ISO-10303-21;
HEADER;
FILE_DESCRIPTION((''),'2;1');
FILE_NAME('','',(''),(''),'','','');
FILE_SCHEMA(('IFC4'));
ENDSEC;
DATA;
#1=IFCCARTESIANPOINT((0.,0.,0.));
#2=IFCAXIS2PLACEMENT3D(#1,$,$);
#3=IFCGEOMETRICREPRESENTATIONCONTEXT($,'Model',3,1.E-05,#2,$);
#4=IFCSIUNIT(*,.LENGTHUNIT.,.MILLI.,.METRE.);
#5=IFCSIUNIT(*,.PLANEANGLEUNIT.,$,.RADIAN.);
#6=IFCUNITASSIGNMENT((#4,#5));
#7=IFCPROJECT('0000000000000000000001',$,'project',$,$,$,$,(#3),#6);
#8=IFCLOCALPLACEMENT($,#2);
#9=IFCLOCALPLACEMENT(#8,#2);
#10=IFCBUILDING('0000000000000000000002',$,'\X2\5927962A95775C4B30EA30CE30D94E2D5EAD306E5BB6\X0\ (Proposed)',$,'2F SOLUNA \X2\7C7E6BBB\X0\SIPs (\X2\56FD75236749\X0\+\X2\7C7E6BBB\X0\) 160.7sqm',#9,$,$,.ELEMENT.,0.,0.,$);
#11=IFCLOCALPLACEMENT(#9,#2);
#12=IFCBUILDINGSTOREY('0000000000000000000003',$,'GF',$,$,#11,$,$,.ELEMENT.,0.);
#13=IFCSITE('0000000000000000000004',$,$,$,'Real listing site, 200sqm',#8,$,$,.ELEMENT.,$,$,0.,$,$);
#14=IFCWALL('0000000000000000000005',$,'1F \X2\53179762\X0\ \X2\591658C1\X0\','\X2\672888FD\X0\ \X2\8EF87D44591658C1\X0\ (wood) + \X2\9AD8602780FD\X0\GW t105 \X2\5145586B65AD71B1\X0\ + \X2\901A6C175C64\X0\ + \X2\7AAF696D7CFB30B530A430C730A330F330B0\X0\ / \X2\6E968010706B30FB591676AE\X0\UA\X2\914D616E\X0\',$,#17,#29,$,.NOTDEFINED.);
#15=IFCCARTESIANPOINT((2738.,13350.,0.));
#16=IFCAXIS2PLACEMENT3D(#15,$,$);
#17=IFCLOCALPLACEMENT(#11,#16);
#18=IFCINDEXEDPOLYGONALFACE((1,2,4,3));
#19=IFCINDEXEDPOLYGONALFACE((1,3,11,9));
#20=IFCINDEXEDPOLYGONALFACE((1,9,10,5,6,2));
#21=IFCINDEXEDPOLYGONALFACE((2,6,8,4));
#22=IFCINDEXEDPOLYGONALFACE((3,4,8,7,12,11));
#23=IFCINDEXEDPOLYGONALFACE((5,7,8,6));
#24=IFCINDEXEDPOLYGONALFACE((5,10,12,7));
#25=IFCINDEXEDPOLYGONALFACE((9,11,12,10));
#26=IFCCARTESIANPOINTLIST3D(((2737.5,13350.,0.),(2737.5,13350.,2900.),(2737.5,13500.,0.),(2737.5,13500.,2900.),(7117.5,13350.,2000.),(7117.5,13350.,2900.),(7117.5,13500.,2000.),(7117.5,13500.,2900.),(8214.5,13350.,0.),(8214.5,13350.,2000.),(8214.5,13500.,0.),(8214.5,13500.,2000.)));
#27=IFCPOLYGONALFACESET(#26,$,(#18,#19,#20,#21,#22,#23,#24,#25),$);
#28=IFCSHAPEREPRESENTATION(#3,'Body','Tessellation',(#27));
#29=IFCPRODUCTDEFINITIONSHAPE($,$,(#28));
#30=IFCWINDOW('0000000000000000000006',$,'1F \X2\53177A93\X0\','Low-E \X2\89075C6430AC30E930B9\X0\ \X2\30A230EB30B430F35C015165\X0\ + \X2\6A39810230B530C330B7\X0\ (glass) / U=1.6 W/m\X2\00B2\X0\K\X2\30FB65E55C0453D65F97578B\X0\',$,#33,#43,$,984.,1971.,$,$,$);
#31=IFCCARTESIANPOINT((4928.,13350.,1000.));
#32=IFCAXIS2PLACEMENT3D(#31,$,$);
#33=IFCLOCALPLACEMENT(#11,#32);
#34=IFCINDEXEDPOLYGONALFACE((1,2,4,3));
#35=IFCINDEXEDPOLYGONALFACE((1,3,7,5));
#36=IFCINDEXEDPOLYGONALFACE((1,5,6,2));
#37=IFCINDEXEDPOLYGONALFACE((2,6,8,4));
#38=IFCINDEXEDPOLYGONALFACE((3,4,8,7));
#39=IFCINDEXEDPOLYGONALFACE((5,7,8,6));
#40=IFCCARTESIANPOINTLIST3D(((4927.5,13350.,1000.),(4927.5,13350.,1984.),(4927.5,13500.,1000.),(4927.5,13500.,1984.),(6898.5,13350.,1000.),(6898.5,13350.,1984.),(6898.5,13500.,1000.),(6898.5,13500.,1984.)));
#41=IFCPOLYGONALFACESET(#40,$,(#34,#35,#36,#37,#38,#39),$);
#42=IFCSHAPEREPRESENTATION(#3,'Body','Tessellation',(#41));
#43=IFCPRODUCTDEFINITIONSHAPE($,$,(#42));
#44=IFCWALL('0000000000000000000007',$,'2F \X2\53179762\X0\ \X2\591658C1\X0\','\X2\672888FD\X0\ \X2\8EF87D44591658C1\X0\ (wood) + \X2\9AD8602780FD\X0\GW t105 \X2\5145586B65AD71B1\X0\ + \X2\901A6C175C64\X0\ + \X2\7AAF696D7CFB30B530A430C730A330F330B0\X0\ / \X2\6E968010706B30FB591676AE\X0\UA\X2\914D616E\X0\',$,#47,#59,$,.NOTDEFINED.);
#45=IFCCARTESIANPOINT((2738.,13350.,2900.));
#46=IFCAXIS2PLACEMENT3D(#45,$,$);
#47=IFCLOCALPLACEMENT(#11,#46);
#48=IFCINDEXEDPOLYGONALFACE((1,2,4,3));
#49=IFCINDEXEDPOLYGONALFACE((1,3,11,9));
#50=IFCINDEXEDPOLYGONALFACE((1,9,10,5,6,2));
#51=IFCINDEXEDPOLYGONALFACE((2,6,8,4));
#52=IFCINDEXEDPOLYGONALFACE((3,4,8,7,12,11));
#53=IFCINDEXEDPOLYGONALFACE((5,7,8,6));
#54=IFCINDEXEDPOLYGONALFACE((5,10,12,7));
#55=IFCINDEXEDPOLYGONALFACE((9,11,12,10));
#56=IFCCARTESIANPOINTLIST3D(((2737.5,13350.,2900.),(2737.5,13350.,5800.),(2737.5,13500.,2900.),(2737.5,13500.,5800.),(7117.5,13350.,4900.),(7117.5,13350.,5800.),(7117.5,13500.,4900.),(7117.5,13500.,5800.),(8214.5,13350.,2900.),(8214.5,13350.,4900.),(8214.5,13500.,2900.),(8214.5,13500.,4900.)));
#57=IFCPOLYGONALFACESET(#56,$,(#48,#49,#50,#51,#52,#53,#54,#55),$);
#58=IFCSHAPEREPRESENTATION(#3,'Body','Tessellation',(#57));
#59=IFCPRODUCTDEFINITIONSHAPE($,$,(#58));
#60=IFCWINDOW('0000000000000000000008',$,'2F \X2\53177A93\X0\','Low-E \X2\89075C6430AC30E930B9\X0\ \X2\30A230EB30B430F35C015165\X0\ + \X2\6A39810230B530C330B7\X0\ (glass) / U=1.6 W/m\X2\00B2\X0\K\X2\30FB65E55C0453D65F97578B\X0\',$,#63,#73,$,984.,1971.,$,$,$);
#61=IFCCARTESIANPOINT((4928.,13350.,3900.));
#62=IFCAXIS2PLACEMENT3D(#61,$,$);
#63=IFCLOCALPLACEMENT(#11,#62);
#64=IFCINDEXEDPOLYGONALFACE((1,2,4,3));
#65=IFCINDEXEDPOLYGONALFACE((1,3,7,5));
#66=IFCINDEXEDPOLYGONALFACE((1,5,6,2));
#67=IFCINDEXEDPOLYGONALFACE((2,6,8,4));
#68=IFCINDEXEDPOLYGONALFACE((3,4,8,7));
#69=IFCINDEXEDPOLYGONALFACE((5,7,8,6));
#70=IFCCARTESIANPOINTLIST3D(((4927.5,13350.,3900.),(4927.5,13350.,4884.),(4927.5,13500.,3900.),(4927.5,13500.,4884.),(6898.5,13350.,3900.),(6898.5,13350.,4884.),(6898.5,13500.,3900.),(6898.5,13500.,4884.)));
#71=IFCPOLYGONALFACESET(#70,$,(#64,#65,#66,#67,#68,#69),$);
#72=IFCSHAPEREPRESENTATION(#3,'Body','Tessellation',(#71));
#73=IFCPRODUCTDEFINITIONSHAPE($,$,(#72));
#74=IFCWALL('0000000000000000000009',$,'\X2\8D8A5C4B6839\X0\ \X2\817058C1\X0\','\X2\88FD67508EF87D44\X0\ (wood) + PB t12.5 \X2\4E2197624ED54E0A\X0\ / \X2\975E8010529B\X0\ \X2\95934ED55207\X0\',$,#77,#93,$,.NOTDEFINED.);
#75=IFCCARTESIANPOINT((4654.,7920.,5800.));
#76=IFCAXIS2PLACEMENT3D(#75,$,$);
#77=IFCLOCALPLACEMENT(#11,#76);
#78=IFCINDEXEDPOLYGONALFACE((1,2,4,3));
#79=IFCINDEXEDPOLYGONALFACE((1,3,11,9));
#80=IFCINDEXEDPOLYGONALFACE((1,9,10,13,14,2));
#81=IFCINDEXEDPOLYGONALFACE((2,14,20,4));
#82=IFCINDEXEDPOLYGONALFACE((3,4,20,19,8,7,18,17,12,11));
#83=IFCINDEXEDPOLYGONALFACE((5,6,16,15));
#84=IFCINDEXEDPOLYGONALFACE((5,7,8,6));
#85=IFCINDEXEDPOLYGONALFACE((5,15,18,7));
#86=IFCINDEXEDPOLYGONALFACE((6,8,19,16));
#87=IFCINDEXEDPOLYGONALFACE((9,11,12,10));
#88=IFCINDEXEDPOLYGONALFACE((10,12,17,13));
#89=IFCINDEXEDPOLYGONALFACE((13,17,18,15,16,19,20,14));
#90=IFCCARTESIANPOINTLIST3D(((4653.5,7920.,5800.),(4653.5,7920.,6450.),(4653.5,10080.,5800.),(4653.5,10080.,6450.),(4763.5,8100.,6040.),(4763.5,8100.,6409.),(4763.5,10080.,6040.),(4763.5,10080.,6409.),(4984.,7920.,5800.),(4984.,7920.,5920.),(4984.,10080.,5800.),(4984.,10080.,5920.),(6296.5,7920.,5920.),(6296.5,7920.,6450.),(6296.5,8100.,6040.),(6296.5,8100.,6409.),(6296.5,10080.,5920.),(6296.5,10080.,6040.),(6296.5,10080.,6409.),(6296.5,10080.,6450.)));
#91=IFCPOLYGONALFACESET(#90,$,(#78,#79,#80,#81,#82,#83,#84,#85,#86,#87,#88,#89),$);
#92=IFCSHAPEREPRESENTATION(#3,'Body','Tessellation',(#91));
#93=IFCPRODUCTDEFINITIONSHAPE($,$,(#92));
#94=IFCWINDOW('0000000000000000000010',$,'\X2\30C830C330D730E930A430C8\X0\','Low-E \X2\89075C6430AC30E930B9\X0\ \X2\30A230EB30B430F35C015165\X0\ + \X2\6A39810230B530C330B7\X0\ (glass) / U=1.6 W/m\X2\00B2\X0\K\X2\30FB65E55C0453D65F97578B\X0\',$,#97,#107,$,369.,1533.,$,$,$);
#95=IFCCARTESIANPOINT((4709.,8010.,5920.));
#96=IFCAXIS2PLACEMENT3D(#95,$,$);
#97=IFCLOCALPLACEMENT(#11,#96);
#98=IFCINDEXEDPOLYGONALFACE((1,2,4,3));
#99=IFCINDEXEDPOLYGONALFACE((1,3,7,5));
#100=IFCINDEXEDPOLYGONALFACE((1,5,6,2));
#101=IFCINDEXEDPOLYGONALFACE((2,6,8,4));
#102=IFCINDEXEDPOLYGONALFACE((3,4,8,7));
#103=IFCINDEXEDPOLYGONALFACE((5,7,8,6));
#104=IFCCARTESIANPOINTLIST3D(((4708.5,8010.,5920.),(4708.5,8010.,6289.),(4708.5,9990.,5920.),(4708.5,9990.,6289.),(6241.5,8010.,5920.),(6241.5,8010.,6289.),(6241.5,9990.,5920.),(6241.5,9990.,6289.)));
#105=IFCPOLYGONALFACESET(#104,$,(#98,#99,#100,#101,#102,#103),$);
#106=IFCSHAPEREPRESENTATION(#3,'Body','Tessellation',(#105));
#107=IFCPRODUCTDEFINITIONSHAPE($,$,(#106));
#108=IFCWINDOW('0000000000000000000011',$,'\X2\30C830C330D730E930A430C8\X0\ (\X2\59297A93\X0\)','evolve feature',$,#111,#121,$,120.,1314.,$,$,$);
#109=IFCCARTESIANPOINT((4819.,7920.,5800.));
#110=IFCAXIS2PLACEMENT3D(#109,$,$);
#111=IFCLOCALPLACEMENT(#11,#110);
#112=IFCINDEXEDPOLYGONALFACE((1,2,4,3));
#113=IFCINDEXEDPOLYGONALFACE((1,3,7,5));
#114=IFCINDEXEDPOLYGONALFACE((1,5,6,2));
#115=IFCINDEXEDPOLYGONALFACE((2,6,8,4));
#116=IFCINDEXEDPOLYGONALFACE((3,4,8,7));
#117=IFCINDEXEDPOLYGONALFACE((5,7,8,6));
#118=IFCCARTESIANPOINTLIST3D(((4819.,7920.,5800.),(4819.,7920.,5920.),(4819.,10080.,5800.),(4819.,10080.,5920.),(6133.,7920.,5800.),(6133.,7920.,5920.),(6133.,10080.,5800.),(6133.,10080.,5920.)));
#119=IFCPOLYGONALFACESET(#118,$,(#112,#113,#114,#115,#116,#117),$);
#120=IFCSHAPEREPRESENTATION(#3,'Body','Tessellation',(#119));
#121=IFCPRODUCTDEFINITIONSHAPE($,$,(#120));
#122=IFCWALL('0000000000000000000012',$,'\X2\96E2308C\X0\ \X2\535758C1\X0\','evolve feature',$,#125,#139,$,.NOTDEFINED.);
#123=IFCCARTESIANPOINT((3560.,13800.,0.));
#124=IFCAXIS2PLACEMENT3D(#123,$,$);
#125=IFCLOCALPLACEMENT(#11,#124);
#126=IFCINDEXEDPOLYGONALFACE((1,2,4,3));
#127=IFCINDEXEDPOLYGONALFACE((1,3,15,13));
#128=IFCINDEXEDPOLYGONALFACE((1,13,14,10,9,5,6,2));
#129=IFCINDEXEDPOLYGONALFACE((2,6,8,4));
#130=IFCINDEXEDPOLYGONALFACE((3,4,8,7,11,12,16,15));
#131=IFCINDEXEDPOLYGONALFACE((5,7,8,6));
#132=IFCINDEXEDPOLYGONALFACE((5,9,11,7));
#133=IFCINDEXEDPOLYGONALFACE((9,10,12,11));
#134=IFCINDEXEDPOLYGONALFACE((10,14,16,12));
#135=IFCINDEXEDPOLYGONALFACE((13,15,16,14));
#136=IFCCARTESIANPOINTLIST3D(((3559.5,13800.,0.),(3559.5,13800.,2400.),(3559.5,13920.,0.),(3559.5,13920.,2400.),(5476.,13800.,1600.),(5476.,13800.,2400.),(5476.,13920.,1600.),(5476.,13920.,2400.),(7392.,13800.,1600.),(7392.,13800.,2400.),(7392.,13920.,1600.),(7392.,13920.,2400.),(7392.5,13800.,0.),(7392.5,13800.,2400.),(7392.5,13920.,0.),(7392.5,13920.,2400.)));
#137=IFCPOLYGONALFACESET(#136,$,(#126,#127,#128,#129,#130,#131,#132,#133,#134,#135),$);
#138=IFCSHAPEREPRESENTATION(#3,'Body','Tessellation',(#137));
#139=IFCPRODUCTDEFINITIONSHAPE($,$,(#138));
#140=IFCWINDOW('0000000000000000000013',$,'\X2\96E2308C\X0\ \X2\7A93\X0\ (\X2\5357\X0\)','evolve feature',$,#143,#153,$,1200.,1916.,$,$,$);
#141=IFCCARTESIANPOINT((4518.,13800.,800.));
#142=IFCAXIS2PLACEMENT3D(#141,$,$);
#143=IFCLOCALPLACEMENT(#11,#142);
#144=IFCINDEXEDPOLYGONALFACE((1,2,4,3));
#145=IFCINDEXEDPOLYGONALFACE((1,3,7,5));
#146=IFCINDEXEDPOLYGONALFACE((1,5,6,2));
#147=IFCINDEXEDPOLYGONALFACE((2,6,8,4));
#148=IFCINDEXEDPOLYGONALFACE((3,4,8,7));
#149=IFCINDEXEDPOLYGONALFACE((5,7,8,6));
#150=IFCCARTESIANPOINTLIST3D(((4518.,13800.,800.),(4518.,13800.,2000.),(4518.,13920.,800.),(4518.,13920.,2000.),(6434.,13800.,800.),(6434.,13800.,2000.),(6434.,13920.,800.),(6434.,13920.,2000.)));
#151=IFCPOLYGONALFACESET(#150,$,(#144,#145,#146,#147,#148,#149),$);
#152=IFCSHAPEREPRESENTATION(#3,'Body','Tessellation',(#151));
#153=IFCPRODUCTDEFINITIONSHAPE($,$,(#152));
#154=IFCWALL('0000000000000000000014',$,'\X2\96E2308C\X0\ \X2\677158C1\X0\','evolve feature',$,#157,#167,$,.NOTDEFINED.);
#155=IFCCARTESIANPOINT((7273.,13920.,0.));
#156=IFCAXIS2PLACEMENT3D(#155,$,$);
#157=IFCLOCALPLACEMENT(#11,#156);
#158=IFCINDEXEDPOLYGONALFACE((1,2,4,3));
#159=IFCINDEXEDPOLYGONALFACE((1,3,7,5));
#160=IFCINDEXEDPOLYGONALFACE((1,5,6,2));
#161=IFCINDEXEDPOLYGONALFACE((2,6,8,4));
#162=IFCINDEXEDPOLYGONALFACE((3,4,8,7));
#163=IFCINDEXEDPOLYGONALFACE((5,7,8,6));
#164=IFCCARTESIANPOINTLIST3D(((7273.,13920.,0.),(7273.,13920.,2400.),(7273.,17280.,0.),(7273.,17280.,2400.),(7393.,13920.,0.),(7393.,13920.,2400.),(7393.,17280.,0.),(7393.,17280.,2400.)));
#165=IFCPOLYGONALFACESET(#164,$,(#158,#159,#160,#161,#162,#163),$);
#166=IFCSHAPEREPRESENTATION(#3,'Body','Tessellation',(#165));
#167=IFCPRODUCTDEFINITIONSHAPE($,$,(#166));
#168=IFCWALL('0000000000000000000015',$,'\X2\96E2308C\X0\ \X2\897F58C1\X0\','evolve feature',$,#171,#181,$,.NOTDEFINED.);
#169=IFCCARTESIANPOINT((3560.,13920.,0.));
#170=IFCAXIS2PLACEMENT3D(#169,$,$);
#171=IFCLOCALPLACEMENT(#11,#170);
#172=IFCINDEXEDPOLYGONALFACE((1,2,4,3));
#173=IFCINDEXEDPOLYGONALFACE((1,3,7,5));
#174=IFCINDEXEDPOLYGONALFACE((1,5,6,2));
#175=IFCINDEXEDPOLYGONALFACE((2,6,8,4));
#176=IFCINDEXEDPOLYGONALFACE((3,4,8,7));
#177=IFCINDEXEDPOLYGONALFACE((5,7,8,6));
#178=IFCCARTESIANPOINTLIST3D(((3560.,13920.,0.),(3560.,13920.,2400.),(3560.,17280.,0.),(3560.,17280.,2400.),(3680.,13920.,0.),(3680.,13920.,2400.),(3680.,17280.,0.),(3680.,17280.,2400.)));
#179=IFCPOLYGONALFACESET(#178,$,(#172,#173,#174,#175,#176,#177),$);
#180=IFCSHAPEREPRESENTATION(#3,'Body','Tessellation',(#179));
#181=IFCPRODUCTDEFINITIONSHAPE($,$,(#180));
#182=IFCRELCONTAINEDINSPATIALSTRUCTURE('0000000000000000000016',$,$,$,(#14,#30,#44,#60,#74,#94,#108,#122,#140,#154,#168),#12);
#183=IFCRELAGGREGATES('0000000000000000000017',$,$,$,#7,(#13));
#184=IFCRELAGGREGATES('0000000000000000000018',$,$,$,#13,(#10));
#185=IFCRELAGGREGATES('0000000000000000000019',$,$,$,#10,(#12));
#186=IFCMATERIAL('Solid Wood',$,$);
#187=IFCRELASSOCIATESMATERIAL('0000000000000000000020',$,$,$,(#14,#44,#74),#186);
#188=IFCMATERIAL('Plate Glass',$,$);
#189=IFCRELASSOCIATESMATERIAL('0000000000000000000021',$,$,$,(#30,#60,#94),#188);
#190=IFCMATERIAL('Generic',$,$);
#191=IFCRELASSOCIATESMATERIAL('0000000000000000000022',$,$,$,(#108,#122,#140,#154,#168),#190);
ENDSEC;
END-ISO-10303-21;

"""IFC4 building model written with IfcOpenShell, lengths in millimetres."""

from ifc_helpers import new_model, si_unit, frame, frame_2d, origin, place, context, project, spatial, rectangle, extrude, material, element, fill, save


model = new_model("IFC4")

# Units and contexts
model_context = context("Model", 3, precision=1e-05, world=origin())
ifc_project = project(units=[si_unit("LENGTHUNIT", "METRE", prefix="MILLI"), si_unit("PLANEANGLEUNIT", "RADIAN")], contexts=[model_context])

# Site, building, storey
site_placement = place(None, origin())
site = spatial("IfcSite", under=ifc_project, at=site_placement, ObjectType="Real listing site, 200sqm", CompositionType="ELEMENT", RefElevation=0.0)
building_placement = place(site_placement, origin())
building = spatial("IfcBuilding", under=site, at=building_placement, Name="大阪長屋リノベ中庭の家 (Proposed)", ObjectType="2F SOLUNA 籾殻SIPs (国産杉+籾殻) 160.7sqm", CompositionType="ELEMENT", ElevationOfRefHeight=0.0, ElevationOfTerrain=0.0)
storey_placement = place(building_placement, origin())
storey = spatial("IfcBuildingStorey", under=building, at=storey_placement, Name="GF", CompositionType="ELEMENT", Elevation=0.0)

# Shared definitions
ifc_material_1 = material(Name="Generic")

# Wall, opening, window
ifc_material_2 = material(Name="Solid Wood")
wall_1_placement = place(storey_placement, frame((2738.0, 13350.0, 0.0)))
wall_1 = element("IfcWall", 1, at=wall_1_placement, inside=storey, material=ifc_material_2, Name="1F 北面 外壁", Description="木製 軸組外壁 (wood) + 高性能GW t105 充填断熱 + 通気層 + 窯業系サイディング / 準耐火・外皮UA配慮", PredefinedType="NOTDEFINED", context=model_context, shape_type="SweptSolid", body=[
    extrude(rectangle(XDim=5477.0, YDim=150.0, at=frame_2d((2738.0, 75.0))), frame((2738.0, 13350.0, 0.0)), (0.0, 0.0, 1.0), 2900.0),
])
opening_1_placement = place(storey_placement, frame((4928.0, 13350.0, 1000.0)))
opening_1 = element("IfcOpeningElement", 2, at=opening_1_placement, cuts=wall_1, PredefinedType="NOTDEFINED", context=model_context, shape_type="SweptSolid", body=[
    extrude(rectangle(XDim=1971.0, YDim=150.0, at=frame_2d((985.0, 75.0))), frame((4928.0, 13350.0, 1000.0)), (0.0, 0.0, 1.0), 984.0),
])
ifc_material_3 = material(Name="Plate Glass")
window_1_placement = place(storey_placement, frame((4928.0, 13350.0, 1000.0)))
window_1 = element("IfcWindow", 3, at=window_1_placement, inside=storey, material=ifc_material_3, Name="1F 北窓", Description="Low-E 複層ガラス アルゴン封入 + 樹脂サッシ (glass) / U=1.6 W/m²K・日射取得型", OverallHeight=984.0, OverallWidth=1971.0, context=model_context, shape_type="SweptSolid", body=[
    extrude(rectangle(XDim=1971.0, YDim=150.0, at=frame_2d((985.0, 75.0))), frame((4928.0, 13350.0, 1000.0)), (0.0, 0.0, 1.0), 984.0),
])
fill(opening_1, window_1)

# Wall, opening, window
wall_2_placement = place(storey_placement, frame((2738.0, 13350.0, 2900.0)))
wall_2 = element("IfcWall", 4, at=wall_2_placement, inside=storey, material=ifc_material_2, Name="2F 北面 外壁", Description="木製 軸組外壁 (wood) + 高性能GW t105 充填断熱 + 通気層 + 窯業系サイディング / 準耐火・外皮UA配慮", PredefinedType="NOTDEFINED", context=model_context, shape_type="SweptSolid", body=[
    extrude(rectangle(XDim=5477.0, YDim=150.0, at=frame_2d((2738.0, 75.0))), frame((2738.0, 13350.0, 2900.0)), (0.0, 0.0, 1.0), 2900.0),
])
opening_2_placement = place(storey_placement, frame((4928.0, 13350.0, 3900.0)))
opening_2 = element("IfcOpeningElement", 5, at=opening_2_placement, cuts=wall_2, PredefinedType="NOTDEFINED", context=model_context, shape_type="SweptSolid", body=[
    extrude(rectangle(XDim=1971.0, YDim=150.0, at=frame_2d((985.0, 75.0))), frame((4928.0, 13350.0, 3900.0)), (0.0, 0.0, 1.0), 984.0),
])
window_2_placement = place(storey_placement, frame((4928.0, 13350.0, 3900.0)))
window_2 = element("IfcWindow", 6, at=window_2_placement, inside=storey, material=ifc_material_3, Name="2F 北窓", Description="Low-E 複層ガラス アルゴン封入 + 樹脂サッシ (glass) / U=1.6 W/m²K・日射取得型", OverallHeight=984.0, OverallWidth=1971.0, context=model_context, shape_type="SweptSolid", body=[
    extrude(rectangle(XDim=1971.0, YDim=150.0, at=frame_2d((985.0, 75.0))), frame((4928.0, 13350.0, 3900.0)), (0.0, 0.0, 1.0), 984.0),
])
fill(opening_2, window_2)

# Wall, openings, windows
wall_3_placement = place(storey_placement, frame((4654.0, 7920.0, 5800.0)))
wall_3 = element("IfcWall", 7, at=wall_3_placement, inside=storey, material=ifc_material_2, Name="越屋根 腰壁", Description="製材軸組 (wood) + PB t12.5 両面仕上 / 非耐力 間仕切", PredefinedType="NOTDEFINED", context=model_context, shape_type="SweptSolid", body=[
    extrude(rectangle(XDim=1643.0, YDim=2160.0, at=frame_2d((821.0, 1080.0))), frame((4654.0, 7920.0, 5800.0)), (0.0, 0.0, 1.0), 650.0),
])
opening_3_placement = place(storey_placement, frame((4709.0, 8010.0, 5920.0)))
opening_3 = element("IfcOpeningElement", 8, at=opening_3_placement, cuts=wall_3, PredefinedType="NOTDEFINED", context=model_context, shape_type="SweptSolid", body=[
    extrude(rectangle(XDim=1533.0, YDim=1980.0, at=frame_2d((766.0, 990.0))), frame((4709.0, 8010.0, 5920.0)), (0.0, 0.0, 1.0), 369.0),
])
opening_4_placement = place(storey_placement, frame((4819.0, 7920.0, 5800.0)))
opening_4 = element("IfcOpeningElement", 9, at=opening_4_placement, cuts=wall_3, PredefinedType="NOTDEFINED", context=model_context, shape_type="SweptSolid", body=[
    extrude(rectangle(XDim=1314.0, YDim=2160.0, at=frame_2d((657.0, 1080.0))), frame((4819.0, 7920.0, 5800.0)), (0.0, 0.0, 1.0), 120.0),
])
window_3_placement = place(storey_placement, frame((4709.0, 8010.0, 5920.0)))
window_3 = element("IfcWindow", 10, at=window_3_placement, inside=storey, material=ifc_material_3, Name="トップライト", Description="Low-E 複層ガラス アルゴン封入 + 樹脂サッシ (glass) / U=1.6 W/m²K・日射取得型", OverallHeight=369.0, OverallWidth=1533.0, context=model_context, shape_type="SweptSolid", body=[
    extrude(rectangle(XDim=1533.0, YDim=1980.0, at=frame_2d((766.0, 990.0))), frame((4709.0, 8010.0, 5920.0)), (0.0, 0.0, 1.0), 369.0),
])
fill(opening_3, window_3)
window_4_placement = place(storey_placement, frame((4819.0, 7920.0, 5800.0)))
window_4 = element("IfcWindow", 11, at=window_4_placement, inside=storey, material=ifc_material_1, Name="トップライト (天窓)", Description="evolve feature", OverallHeight=120.0, OverallWidth=1314.0, context=model_context, shape_type="SweptSolid", body=[
    extrude(rectangle(XDim=1314.0, YDim=2160.0, at=frame_2d((657.0, 1080.0))), frame((4819.0, 7920.0, 5800.0)), (0.0, 0.0, 1.0), 120.0),
])
fill(opening_4, window_4)

# Wall, opening, window
wall_4_placement = place(storey_placement, frame((3560.0, 13800.0, 0.0)))
wall_4 = element("IfcWall", 12, at=wall_4_placement, inside=storey, material=ifc_material_1, Name="離れ 南壁", Description="evolve feature", PredefinedType="NOTDEFINED", context=model_context, shape_type="SweptSolid", body=[
    extrude(rectangle(XDim=3833.0, YDim=120.0, at=frame_2d((1916.0, 60.0))), frame((3560.0, 13800.0, 0.0)), (0.0, 0.0, 1.0), 2400.0),
])
opening_5_placement = place(storey_placement, frame((4518.0, 13800.0, 800.0)))
opening_5 = element("IfcOpeningElement", 13, at=opening_5_placement, cuts=wall_4, PredefinedType="NOTDEFINED", context=model_context, shape_type="SweptSolid", body=[
    extrude(rectangle(XDim=1916.0, YDim=120.0, at=frame_2d((958.0, 60.0))), frame((4518.0, 13800.0, 800.0)), (0.0, 0.0, 1.0), 1200.0),
])
window_5_placement = place(storey_placement, frame((4518.0, 13800.0, 800.0)))
window_5 = element("IfcWindow", 14, at=window_5_placement, inside=storey, material=ifc_material_1, Name="離れ 窓 (南)", Description="evolve feature", OverallHeight=1200.0, OverallWidth=1916.0, context=model_context, shape_type="SweptSolid", body=[
    extrude(rectangle(XDim=1916.0, YDim=120.0, at=frame_2d((958.0, 60.0))), frame((4518.0, 13800.0, 800.0)), (0.0, 0.0, 1.0), 1200.0),
])
fill(opening_5, window_5)

# Walls
wall_5_placement = place(storey_placement, frame((7273.0, 13920.0, 0.0)))
element("IfcWall", 15, at=wall_5_placement, inside=storey, material=ifc_material_1, Name="離れ 東壁", Description="evolve feature", PredefinedType="NOTDEFINED", context=model_context, shape_type="SweptSolid", body=[
    extrude(rectangle(XDim=120.0, YDim=3360.0, at=frame_2d((60.0, 1680.0))), frame((7273.0, 13920.0, 0.0)), (0.0, 0.0, 1.0), 2400.0),
])
wall_6_placement = place(storey_placement, frame((3560.0, 13920.0, 0.0)))
element("IfcWall", 16, at=wall_6_placement, inside=storey, material=ifc_material_1, Name="離れ 西壁", Description="evolve feature", PredefinedType="NOTDEFINED", context=model_context, shape_type="SweptSolid", body=[
    extrude(rectangle(XDim=120.0, YDim=3360.0, at=frame_2d((60.0, 1680.0))), frame((3560.0, 13920.0, 0.0)), (0.0, 0.0, 1.0), 2400.0),
])

save(model, "model.ifc")
